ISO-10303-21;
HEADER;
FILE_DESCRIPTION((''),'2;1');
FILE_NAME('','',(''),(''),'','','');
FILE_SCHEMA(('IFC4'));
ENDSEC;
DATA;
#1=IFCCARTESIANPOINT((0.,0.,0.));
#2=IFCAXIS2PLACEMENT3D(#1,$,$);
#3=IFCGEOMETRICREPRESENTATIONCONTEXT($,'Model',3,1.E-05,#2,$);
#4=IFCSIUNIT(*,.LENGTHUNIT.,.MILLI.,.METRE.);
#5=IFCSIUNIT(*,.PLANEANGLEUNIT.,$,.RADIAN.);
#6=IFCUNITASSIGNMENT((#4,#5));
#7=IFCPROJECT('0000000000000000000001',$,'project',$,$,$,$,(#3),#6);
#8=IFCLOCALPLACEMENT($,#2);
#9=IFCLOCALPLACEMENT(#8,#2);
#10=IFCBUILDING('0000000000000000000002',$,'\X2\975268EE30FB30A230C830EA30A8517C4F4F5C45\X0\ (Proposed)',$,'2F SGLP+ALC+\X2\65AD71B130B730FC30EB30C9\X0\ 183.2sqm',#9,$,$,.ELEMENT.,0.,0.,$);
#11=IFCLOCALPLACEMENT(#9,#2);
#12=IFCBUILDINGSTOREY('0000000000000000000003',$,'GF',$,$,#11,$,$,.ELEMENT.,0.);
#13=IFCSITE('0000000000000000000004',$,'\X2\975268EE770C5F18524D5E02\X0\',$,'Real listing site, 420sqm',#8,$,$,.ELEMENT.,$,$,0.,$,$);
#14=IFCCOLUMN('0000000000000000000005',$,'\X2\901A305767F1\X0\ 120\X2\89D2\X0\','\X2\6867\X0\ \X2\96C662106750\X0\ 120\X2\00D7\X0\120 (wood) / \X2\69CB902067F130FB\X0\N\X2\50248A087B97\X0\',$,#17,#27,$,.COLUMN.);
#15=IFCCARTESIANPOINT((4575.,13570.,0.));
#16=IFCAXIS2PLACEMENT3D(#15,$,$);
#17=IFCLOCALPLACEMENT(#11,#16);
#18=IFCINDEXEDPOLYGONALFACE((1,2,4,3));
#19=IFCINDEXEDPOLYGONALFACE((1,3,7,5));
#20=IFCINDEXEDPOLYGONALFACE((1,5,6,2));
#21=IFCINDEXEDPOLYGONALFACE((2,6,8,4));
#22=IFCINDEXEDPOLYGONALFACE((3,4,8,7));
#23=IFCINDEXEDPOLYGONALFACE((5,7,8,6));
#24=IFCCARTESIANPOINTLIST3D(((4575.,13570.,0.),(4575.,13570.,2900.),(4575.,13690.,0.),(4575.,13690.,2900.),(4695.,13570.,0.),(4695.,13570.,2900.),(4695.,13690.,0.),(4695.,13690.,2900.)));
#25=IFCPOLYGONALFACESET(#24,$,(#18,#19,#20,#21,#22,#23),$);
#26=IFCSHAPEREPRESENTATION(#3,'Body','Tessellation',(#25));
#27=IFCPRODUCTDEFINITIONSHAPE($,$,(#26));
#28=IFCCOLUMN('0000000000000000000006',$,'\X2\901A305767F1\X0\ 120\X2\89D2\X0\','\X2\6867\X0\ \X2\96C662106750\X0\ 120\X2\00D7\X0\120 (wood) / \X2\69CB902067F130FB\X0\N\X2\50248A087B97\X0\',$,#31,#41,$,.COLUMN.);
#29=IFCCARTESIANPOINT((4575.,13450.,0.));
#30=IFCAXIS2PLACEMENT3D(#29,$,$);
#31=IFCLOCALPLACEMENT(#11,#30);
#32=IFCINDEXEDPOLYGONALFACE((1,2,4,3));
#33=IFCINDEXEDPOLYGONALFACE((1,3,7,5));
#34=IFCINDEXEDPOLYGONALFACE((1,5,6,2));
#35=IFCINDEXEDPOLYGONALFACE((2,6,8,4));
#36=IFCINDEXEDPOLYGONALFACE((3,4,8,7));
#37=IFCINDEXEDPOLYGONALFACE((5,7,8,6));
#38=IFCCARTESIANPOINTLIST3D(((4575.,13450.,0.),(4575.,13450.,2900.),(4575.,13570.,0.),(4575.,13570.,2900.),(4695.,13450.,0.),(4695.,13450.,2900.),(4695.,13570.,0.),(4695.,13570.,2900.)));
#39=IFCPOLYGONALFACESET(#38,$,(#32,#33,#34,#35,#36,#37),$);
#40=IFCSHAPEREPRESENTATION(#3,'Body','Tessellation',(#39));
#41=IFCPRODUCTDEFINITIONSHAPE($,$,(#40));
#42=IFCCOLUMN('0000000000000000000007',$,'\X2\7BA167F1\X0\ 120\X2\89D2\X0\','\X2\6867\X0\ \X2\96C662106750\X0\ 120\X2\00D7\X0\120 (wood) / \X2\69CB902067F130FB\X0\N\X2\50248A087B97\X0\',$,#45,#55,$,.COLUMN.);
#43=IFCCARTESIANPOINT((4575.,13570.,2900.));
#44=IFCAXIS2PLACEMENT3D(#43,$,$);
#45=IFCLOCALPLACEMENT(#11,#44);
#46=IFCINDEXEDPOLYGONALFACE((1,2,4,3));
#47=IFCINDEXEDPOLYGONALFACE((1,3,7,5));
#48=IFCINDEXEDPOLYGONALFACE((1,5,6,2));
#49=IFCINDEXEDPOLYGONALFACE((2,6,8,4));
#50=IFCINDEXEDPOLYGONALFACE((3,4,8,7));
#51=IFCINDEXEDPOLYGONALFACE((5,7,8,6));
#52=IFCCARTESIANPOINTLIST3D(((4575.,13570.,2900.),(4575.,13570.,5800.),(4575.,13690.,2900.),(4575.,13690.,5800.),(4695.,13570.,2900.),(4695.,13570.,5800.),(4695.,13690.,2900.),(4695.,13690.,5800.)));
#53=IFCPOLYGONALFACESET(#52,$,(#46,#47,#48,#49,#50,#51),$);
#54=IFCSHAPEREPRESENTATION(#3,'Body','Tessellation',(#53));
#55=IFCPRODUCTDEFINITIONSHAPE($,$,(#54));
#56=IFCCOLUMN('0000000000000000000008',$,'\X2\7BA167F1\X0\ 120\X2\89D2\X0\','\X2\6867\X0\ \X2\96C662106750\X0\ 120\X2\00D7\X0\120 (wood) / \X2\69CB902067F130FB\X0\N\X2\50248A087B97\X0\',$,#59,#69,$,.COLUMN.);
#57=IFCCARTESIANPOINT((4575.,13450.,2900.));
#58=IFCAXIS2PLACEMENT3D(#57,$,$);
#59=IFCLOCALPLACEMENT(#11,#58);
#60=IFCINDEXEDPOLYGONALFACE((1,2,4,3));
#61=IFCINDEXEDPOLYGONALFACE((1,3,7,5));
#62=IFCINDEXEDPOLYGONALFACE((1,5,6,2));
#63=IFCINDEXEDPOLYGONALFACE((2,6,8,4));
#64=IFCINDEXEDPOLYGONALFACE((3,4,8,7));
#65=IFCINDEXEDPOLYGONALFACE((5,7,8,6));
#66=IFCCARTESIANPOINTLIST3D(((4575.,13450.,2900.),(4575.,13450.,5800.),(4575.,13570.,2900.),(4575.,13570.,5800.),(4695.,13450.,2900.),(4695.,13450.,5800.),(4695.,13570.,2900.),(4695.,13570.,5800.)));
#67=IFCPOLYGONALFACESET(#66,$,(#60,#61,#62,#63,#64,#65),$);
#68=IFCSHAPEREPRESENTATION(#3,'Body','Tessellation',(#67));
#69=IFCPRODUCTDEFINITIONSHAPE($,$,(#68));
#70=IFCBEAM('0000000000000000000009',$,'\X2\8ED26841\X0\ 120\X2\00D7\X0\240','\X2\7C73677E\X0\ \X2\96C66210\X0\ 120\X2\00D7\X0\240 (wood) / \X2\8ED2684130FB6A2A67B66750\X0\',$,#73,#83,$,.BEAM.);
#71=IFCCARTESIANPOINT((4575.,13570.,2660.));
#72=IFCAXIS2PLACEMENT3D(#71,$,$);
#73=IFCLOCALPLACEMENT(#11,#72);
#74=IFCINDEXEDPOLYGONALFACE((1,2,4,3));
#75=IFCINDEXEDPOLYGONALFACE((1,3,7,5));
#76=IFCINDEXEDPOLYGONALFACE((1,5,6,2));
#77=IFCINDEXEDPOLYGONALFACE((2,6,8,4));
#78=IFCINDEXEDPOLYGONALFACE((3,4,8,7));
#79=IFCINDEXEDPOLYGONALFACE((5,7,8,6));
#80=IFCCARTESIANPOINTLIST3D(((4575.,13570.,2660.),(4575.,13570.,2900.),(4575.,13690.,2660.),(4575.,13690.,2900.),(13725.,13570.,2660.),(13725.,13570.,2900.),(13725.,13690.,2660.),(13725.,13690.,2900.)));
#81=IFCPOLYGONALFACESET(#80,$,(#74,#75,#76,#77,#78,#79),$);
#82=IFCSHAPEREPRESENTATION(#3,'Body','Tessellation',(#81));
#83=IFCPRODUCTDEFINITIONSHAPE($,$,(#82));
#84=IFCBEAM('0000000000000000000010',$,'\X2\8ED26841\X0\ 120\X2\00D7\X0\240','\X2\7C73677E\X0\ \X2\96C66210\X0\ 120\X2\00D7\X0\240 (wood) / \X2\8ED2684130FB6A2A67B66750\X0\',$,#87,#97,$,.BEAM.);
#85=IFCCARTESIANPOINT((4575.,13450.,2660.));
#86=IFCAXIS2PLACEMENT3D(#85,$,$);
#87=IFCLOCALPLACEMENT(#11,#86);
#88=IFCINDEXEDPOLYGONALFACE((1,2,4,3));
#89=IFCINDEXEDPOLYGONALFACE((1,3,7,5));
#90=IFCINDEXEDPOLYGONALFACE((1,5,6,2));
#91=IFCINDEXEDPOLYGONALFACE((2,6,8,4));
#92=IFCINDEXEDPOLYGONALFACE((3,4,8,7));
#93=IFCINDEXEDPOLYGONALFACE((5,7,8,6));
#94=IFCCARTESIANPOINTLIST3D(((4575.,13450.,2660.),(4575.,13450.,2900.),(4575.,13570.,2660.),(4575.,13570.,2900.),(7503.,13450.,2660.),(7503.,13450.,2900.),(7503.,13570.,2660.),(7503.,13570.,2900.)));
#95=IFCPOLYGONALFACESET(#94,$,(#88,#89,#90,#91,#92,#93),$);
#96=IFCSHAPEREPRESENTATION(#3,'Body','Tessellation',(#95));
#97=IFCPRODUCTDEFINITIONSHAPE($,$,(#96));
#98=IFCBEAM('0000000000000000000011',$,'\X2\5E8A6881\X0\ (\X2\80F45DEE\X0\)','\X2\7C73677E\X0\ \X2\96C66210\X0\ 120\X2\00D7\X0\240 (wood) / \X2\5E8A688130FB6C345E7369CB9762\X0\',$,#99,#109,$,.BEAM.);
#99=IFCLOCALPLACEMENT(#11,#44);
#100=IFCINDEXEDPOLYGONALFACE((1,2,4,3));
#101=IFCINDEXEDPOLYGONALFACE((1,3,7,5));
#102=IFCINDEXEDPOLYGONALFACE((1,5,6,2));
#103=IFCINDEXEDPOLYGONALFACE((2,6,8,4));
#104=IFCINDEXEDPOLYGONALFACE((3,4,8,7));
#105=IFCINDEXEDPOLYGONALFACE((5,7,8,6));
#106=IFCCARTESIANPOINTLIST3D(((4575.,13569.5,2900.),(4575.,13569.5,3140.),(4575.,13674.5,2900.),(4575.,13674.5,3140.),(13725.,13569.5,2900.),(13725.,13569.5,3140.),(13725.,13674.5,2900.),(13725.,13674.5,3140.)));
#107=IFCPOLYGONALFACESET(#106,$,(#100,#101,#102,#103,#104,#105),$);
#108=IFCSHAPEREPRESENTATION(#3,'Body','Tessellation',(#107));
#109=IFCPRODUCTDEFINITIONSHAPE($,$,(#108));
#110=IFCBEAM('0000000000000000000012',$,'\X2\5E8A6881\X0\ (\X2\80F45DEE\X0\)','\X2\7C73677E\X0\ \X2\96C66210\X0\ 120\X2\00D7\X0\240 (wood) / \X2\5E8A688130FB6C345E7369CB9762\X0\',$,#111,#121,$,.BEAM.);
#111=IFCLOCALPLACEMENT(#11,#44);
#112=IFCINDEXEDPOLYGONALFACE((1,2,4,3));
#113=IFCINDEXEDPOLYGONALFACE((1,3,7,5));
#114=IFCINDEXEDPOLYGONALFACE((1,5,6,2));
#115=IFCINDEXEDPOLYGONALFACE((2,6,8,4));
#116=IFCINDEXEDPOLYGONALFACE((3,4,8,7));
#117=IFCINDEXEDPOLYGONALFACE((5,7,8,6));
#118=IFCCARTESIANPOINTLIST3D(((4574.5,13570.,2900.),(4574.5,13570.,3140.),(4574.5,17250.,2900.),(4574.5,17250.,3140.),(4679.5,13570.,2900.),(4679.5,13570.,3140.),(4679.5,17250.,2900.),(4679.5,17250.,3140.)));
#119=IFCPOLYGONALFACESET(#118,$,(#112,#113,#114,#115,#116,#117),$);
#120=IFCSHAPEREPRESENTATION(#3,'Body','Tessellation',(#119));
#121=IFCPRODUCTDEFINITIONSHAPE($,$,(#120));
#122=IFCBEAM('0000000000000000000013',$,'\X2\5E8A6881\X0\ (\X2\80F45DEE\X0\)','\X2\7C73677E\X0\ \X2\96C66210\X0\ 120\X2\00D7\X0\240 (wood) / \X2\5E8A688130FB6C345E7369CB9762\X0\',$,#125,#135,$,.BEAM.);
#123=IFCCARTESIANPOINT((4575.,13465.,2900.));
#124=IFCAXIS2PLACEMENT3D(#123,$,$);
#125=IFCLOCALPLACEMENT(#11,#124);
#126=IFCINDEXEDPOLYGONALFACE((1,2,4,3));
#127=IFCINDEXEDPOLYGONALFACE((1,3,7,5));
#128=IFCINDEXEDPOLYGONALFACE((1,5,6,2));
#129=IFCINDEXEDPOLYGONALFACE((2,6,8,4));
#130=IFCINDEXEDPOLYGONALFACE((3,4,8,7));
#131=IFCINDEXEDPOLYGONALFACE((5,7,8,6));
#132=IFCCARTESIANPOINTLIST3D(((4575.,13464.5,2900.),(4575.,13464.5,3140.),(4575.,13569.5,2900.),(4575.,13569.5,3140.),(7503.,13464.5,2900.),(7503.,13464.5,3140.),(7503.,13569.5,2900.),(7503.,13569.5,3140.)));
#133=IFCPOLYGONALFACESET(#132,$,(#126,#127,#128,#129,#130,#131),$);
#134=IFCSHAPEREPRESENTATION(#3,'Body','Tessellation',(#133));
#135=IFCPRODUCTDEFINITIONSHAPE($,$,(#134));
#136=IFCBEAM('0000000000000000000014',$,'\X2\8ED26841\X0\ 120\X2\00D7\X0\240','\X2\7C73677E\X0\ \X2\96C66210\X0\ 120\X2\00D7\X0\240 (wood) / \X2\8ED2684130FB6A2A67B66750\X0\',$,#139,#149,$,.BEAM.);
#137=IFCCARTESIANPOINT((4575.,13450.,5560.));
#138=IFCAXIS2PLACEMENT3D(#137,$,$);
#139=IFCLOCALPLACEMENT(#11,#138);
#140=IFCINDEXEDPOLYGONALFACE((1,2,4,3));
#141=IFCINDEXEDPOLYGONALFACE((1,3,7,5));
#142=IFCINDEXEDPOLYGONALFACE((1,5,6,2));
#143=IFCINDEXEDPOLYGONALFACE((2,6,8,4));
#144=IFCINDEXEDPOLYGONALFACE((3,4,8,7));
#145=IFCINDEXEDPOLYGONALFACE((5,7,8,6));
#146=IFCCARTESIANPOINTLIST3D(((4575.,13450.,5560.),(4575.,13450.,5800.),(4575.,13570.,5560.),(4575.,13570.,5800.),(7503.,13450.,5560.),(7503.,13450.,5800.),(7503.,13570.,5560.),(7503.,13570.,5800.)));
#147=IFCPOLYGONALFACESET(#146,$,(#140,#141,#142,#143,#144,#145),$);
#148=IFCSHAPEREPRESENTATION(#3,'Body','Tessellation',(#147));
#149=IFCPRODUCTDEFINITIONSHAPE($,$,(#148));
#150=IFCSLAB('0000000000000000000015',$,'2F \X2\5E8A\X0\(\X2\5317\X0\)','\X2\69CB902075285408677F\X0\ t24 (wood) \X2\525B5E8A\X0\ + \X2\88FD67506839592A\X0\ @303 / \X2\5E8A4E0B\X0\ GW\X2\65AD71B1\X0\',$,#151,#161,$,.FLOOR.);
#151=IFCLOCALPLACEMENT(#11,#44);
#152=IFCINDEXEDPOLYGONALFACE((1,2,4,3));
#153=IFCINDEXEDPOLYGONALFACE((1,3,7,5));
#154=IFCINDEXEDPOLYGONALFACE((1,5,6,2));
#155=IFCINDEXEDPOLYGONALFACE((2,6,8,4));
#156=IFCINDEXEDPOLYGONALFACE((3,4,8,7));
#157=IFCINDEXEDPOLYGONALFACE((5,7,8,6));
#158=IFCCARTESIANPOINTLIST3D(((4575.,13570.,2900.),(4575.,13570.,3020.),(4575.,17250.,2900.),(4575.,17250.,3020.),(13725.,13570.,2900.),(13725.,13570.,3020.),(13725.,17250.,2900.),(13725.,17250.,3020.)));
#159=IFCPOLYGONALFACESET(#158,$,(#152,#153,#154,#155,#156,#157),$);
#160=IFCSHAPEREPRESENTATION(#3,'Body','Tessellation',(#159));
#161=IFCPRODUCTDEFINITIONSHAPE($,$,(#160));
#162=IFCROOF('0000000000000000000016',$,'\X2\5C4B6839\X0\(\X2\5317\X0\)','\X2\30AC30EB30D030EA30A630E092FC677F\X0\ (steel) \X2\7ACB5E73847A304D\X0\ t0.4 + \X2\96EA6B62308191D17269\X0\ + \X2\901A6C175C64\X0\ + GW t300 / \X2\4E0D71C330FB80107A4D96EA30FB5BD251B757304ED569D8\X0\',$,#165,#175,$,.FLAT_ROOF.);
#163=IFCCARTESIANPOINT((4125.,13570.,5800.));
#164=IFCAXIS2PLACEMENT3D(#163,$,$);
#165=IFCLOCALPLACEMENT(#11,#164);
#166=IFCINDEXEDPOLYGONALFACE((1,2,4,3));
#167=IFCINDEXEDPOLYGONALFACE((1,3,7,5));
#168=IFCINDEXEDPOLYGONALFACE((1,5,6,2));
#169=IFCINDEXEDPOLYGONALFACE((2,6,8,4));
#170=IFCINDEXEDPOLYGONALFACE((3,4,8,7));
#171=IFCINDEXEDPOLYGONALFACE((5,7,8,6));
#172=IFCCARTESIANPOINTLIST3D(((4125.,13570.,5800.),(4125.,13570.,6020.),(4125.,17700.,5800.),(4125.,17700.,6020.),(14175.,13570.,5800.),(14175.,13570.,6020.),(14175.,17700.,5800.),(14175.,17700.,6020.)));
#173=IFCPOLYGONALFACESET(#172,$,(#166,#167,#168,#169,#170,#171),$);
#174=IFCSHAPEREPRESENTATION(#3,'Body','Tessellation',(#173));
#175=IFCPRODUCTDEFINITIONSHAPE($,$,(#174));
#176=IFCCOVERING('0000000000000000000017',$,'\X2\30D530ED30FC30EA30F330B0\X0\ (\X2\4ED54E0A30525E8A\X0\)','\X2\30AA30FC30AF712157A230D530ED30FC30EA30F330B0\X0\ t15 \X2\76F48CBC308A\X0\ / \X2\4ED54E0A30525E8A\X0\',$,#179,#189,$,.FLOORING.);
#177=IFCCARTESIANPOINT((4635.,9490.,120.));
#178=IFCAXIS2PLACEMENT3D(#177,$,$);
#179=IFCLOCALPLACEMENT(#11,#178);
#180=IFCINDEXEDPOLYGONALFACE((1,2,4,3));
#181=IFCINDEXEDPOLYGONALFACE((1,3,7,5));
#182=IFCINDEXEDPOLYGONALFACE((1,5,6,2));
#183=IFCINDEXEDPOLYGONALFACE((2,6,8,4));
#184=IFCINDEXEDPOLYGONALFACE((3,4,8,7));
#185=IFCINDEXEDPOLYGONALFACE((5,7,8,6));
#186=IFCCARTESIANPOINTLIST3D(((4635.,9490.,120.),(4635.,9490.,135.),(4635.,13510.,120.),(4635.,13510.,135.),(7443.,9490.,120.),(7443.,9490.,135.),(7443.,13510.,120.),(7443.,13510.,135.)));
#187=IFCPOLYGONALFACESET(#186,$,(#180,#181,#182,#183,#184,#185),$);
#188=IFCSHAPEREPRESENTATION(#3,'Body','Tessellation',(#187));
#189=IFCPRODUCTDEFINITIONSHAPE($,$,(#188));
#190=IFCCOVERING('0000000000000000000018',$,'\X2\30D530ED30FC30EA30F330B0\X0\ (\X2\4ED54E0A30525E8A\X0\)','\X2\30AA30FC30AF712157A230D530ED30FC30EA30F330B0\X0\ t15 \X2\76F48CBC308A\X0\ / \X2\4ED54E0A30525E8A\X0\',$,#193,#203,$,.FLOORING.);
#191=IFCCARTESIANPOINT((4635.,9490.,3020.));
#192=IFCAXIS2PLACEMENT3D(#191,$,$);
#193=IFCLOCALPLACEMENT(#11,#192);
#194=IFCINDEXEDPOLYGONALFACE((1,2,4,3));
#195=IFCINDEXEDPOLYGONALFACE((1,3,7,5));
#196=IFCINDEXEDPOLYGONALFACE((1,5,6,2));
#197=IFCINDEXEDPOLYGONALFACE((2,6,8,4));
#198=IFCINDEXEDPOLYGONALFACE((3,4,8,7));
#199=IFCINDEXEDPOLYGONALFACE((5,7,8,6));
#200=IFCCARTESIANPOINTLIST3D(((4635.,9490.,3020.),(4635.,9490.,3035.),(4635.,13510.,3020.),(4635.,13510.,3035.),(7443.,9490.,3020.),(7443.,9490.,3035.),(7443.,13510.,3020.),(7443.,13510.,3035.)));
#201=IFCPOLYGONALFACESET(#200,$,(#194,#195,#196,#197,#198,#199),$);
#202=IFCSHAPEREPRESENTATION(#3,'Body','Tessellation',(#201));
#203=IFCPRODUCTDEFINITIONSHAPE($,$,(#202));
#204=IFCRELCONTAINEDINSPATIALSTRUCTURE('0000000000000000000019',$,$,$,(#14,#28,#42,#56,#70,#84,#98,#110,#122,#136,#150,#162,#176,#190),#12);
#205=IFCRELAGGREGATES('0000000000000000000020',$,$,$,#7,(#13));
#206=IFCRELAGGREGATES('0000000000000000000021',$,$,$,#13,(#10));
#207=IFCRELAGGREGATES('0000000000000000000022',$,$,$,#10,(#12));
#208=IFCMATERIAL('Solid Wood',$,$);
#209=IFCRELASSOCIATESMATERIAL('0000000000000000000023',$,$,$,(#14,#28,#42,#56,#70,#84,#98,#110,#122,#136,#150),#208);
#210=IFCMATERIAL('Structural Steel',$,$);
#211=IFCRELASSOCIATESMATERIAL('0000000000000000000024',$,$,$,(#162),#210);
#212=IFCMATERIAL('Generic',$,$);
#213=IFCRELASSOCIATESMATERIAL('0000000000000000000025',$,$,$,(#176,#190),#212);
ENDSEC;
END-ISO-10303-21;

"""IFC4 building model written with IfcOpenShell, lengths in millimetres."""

from ifc_helpers import new_model, si_unit, frame, frame_2d, origin, place, context, project, spatial, rectangle, extrude, material, element, save


model = new_model("IFC4")

# Units and contexts
model_context = context("Model", 3, precision=1e-05, world=origin())
ifc_project = project(units=[si_unit("LENGTHUNIT", "METRE", prefix="MILLI"), si_unit("PLANEANGLEUNIT", "RADIAN")], contexts=[model_context])

# Site, building, storey
site_placement = place(None, origin())
site = spatial("IfcSite", under=ifc_project, at=site_placement, Name="青森県弘前市", ObjectType="Real listing site, 420sqm", CompositionType="ELEMENT", RefElevation=0.0)
building_placement = place(site_placement, origin())
building = spatial("IfcBuilding", under=site, at=building_placement, Name="青森・アトリエ兼住居 (Proposed)", ObjectType="2F SGLP+ALC+断熱シールド 183.2sqm", CompositionType="ELEMENT", ElevationOfRefHeight=0.0, ElevationOfTerrain=0.0)
storey_placement = place(building_placement, origin())
storey = spatial("IfcBuildingStorey", under=building, at=storey_placement, Name="GF", CompositionType="ELEMENT", Elevation=0.0)

# Columns
ifc_material_1 = material(Name="Solid Wood")
column_1_placement = place(storey_placement, frame((4575.0, 13570.0, 0.0)))
element("IfcColumn", 1, at=column_1_placement, inside=storey, material=ifc_material_1, Name="通し柱 120角", Description="桧 集成材 120×120 (wood) / 構造柱・N値計算", PredefinedType="COLUMN", context=model_context, shape_type="SweptSolid", body=[
    extrude(rectangle(XDim=120.0, YDim=120.0, at=frame_2d((60.0, 60.0))), frame((4575.0, 13570.0, 0.0)), (0.0, 0.0, 1.0), 2900.0),
])
column_2_placement = place(storey_placement, frame((4575.0, 13450.0, 0.0)))
element("IfcColumn", 2, at=column_2_placement, inside=storey, material=ifc_material_1, Name="通し柱 120角", Description="桧 集成材 120×120 (wood) / 構造柱・N値計算", PredefinedType="COLUMN", context=model_context, shape_type="SweptSolid", body=[
    extrude(rectangle(XDim=120.0, YDim=120.0, at=frame_2d((60.0, 60.0))), frame((4575.0, 13450.0, 0.0)), (0.0, 0.0, 1.0), 2900.0),
])
column_3_placement = place(storey_placement, frame((4575.0, 13570.0, 2900.0)))
element("IfcColumn", 3, at=column_3_placement, inside=storey, material=ifc_material_1, Name="管柱 120角", Description="桧 集成材 120×120 (wood) / 構造柱・N値計算", PredefinedType="COLUMN", context=model_context, shape_type="SweptSolid", body=[
    extrude(rectangle(XDim=120.0, YDim=120.0, at=frame_2d((60.0, 60.0))), frame((4575.0, 13570.0, 2900.0)), (0.0, 0.0, 1.0), 2900.0),
])
column_4_placement = place(storey_placement, frame((4575.0, 13450.0, 2900.0)))
element("IfcColumn", 4, at=column_4_placement, inside=storey, material=ifc_material_1, Name="管柱 120角", Description="桧 集成材 120×120 (wood) / 構造柱・N値計算", PredefinedType="COLUMN", context=model_context, shape_type="SweptSolid", body=[
    extrude(rectangle(XDim=120.0, YDim=120.0, at=frame_2d((60.0, 60.0))), frame((4575.0, 13450.0, 2900.0)), (0.0, 0.0, 1.0), 2900.0),
])

# Beams
beam_1_placement = place(storey_placement, frame((4575.0, 13570.0, 2660.0)))
element("IfcBeam", 5, at=beam_1_placement, inside=storey, material=ifc_material_1, Name="軒桁 120×240", Description="米松 集成 120×240 (wood) / 軒桁・横架材", PredefinedType="BEAM", context=model_context, shape_type="SweptSolid", body=[
    extrude(rectangle(XDim=9150.0, YDim=120.0, at=frame_2d((4575.0, 60.0))), frame((4575.0, 13570.0, 2660.0)), (0.0, 0.0, 1.0), 240.0),
])
beam_2_placement = place(storey_placement, frame((4575.0, 13450.0, 2660.0)))
element("IfcBeam", 6, at=beam_2_placement, inside=storey, material=ifc_material_1, Name="軒桁 120×240", Description="米松 集成 120×240 (wood) / 軒桁・横架材", PredefinedType="BEAM", context=model_context, shape_type="SweptSolid", body=[
    extrude(rectangle(XDim=2928.0, YDim=120.0, at=frame_2d((1464.0, 60.0))), frame((4575.0, 13450.0, 2660.0)), (0.0, 0.0, 1.0), 240.0),
])
beam_3_placement = place(storey_placement, frame((4575.0, 13570.0, 2900.0)))
element("IfcBeam", 7, at=beam_3_placement, inside=storey, material=ifc_material_1, Name="床梁 (胴差)", Description="米松 集成 120×240 (wood) / 床梁・水平構面", PredefinedType="BEAM", context=model_context, shape_type="SweptSolid", body=[
    extrude(rectangle(XDim=9150.0, YDim=105.0, at=frame_2d((4575.0, 52.0))), frame((4575.0, 13570.0, 2900.0)), (0.0, 0.0, 1.0), 240.0),
])
beam_4_placement = place(storey_placement, frame((4575.0, 13570.0, 2900.0)))
element("IfcBeam", 8, at=beam_4_placement, inside=storey, material=ifc_material_1, Name="床梁 (胴差)", Description="米松 集成 120×240 (wood) / 床梁・水平構面", PredefinedType="BEAM", context=model_context, shape_type="SweptSolid", body=[
    extrude(rectangle(XDim=105.0, YDim=3680.0, at=frame_2d((52.0, 1840.0))), frame((4575.0, 13570.0, 2900.0)), (0.0, 0.0, 1.0), 240.0),
])
beam_5_placement = place(storey_placement, frame((4575.0, 13465.0, 2900.0)))
element("IfcBeam", 9, at=beam_5_placement, inside=storey, material=ifc_material_1, Name="床梁 (胴差)", Description="米松 集成 120×240 (wood) / 床梁・水平構面", PredefinedType="BEAM", context=model_context, shape_type="SweptSolid", body=[
    extrude(rectangle(XDim=2928.0, YDim=105.0, at=frame_2d((1464.0, 52.0))), frame((4575.0, 13465.0, 2900.0)), (0.0, 0.0, 1.0), 240.0),
])
beam_6_placement = place(storey_placement, frame((4575.0, 13450.0, 5560.0)))
element("IfcBeam", 10, at=beam_6_placement, inside=storey, material=ifc_material_1, Name="軒桁 120×240", Description="米松 集成 120×240 (wood) / 軒桁・横架材", PredefinedType="BEAM", context=model_context, shape_type="SweptSolid", body=[
    extrude(rectangle(XDim=2928.0, YDim=120.0, at=frame_2d((1464.0, 60.0))), frame((4575.0, 13450.0, 5560.0)), (0.0, 0.0, 1.0), 240.0),
])

# Slab
slab_1_placement = place(storey_placement, frame((4575.0, 13570.0, 2900.0)))
element("IfcSlab", 11, at=slab_1_placement, inside=storey, material=ifc_material_1, Name="2F 床(北)", Description="構造用合板 t24 (wood) 剛床 + 製材根太 @303 / 床下 GW断熱", PredefinedType="FLOOR", context=model_context, shape_type="SweptSolid", body=[
    extrude(rectangle(XDim=9150.0, YDim=3680.0, at=frame_2d((4575.0, 1840.0))), frame((4575.0, 13570.0, 2900.0)), (0.0, 0.0, 1.0), 120.0),
])

# Roof
ifc_material_2 = material(Name="Structural Steel")
for number, where, name in (
    (12, (4125.0, 13570.0, 5800.0), "屋根(北)"),
):
    element("IfcRoof", number, at=place(storey_placement, frame(where)), inside=storey, material=ifc_material_2, Name=name, Description="ガルバリウム鋼板 (steel) 立平葺き t0.4 + 雪止め金物 + 通気層 + GW t300 / 不燃・耐積雪・寒冷地仕様", PredefinedType="FLAT_ROOF", context=model_context, shape_type="SweptSolid", body=[
        extrude(rectangle(XDim=10050.0, YDim=4130.0, at=frame_2d((5025.0, 2065.0))), frame((4125.0, 13570.0, 5800.0)), (0.0, 0.0, 1.0), 220.0),
    ])

# Coverings
ifc_material_3 = material(Name="Generic")
covering_1_placement = place(storey_placement, frame((4635.0, 9490.0, 120.0)))
element("IfcCovering", 13, at=covering_1_placement, inside=storey, material=ifc_material_3, Name="フローリング (仕上げ床)", Description="オーク無垢フローリング t15 直貼り / 仕上げ床", PredefinedType="FLOORING", context=model_context, shape_type="SweptSolid", body=[
    extrude(rectangle(XDim=2808.0, YDim=4020.0, at=frame_2d((1404.0, 2010.0))), frame((4635.0, 9490.0, 120.0)), (0.0, 0.0, 1.0), 15.0),
])
covering_2_placement = place(storey_placement, frame((4635.0, 9490.0, 3020.0)))
element("IfcCovering", 14, at=covering_2_placement, inside=storey, material=ifc_material_3, Name="フローリング (仕上げ床)", Description="オーク無垢フローリング t15 直貼り / 仕上げ床", PredefinedType="FLOORING", context=model_context, shape_type="SweptSolid", body=[
    extrude(rectangle(XDim=2808.0, YDim=4020.0, at=frame_2d((1404.0, 2010.0))), frame((4635.0, 9490.0, 3020.0)), (0.0, 0.0, 1.0), 15.0),
])

save(model, "model.ifc")
